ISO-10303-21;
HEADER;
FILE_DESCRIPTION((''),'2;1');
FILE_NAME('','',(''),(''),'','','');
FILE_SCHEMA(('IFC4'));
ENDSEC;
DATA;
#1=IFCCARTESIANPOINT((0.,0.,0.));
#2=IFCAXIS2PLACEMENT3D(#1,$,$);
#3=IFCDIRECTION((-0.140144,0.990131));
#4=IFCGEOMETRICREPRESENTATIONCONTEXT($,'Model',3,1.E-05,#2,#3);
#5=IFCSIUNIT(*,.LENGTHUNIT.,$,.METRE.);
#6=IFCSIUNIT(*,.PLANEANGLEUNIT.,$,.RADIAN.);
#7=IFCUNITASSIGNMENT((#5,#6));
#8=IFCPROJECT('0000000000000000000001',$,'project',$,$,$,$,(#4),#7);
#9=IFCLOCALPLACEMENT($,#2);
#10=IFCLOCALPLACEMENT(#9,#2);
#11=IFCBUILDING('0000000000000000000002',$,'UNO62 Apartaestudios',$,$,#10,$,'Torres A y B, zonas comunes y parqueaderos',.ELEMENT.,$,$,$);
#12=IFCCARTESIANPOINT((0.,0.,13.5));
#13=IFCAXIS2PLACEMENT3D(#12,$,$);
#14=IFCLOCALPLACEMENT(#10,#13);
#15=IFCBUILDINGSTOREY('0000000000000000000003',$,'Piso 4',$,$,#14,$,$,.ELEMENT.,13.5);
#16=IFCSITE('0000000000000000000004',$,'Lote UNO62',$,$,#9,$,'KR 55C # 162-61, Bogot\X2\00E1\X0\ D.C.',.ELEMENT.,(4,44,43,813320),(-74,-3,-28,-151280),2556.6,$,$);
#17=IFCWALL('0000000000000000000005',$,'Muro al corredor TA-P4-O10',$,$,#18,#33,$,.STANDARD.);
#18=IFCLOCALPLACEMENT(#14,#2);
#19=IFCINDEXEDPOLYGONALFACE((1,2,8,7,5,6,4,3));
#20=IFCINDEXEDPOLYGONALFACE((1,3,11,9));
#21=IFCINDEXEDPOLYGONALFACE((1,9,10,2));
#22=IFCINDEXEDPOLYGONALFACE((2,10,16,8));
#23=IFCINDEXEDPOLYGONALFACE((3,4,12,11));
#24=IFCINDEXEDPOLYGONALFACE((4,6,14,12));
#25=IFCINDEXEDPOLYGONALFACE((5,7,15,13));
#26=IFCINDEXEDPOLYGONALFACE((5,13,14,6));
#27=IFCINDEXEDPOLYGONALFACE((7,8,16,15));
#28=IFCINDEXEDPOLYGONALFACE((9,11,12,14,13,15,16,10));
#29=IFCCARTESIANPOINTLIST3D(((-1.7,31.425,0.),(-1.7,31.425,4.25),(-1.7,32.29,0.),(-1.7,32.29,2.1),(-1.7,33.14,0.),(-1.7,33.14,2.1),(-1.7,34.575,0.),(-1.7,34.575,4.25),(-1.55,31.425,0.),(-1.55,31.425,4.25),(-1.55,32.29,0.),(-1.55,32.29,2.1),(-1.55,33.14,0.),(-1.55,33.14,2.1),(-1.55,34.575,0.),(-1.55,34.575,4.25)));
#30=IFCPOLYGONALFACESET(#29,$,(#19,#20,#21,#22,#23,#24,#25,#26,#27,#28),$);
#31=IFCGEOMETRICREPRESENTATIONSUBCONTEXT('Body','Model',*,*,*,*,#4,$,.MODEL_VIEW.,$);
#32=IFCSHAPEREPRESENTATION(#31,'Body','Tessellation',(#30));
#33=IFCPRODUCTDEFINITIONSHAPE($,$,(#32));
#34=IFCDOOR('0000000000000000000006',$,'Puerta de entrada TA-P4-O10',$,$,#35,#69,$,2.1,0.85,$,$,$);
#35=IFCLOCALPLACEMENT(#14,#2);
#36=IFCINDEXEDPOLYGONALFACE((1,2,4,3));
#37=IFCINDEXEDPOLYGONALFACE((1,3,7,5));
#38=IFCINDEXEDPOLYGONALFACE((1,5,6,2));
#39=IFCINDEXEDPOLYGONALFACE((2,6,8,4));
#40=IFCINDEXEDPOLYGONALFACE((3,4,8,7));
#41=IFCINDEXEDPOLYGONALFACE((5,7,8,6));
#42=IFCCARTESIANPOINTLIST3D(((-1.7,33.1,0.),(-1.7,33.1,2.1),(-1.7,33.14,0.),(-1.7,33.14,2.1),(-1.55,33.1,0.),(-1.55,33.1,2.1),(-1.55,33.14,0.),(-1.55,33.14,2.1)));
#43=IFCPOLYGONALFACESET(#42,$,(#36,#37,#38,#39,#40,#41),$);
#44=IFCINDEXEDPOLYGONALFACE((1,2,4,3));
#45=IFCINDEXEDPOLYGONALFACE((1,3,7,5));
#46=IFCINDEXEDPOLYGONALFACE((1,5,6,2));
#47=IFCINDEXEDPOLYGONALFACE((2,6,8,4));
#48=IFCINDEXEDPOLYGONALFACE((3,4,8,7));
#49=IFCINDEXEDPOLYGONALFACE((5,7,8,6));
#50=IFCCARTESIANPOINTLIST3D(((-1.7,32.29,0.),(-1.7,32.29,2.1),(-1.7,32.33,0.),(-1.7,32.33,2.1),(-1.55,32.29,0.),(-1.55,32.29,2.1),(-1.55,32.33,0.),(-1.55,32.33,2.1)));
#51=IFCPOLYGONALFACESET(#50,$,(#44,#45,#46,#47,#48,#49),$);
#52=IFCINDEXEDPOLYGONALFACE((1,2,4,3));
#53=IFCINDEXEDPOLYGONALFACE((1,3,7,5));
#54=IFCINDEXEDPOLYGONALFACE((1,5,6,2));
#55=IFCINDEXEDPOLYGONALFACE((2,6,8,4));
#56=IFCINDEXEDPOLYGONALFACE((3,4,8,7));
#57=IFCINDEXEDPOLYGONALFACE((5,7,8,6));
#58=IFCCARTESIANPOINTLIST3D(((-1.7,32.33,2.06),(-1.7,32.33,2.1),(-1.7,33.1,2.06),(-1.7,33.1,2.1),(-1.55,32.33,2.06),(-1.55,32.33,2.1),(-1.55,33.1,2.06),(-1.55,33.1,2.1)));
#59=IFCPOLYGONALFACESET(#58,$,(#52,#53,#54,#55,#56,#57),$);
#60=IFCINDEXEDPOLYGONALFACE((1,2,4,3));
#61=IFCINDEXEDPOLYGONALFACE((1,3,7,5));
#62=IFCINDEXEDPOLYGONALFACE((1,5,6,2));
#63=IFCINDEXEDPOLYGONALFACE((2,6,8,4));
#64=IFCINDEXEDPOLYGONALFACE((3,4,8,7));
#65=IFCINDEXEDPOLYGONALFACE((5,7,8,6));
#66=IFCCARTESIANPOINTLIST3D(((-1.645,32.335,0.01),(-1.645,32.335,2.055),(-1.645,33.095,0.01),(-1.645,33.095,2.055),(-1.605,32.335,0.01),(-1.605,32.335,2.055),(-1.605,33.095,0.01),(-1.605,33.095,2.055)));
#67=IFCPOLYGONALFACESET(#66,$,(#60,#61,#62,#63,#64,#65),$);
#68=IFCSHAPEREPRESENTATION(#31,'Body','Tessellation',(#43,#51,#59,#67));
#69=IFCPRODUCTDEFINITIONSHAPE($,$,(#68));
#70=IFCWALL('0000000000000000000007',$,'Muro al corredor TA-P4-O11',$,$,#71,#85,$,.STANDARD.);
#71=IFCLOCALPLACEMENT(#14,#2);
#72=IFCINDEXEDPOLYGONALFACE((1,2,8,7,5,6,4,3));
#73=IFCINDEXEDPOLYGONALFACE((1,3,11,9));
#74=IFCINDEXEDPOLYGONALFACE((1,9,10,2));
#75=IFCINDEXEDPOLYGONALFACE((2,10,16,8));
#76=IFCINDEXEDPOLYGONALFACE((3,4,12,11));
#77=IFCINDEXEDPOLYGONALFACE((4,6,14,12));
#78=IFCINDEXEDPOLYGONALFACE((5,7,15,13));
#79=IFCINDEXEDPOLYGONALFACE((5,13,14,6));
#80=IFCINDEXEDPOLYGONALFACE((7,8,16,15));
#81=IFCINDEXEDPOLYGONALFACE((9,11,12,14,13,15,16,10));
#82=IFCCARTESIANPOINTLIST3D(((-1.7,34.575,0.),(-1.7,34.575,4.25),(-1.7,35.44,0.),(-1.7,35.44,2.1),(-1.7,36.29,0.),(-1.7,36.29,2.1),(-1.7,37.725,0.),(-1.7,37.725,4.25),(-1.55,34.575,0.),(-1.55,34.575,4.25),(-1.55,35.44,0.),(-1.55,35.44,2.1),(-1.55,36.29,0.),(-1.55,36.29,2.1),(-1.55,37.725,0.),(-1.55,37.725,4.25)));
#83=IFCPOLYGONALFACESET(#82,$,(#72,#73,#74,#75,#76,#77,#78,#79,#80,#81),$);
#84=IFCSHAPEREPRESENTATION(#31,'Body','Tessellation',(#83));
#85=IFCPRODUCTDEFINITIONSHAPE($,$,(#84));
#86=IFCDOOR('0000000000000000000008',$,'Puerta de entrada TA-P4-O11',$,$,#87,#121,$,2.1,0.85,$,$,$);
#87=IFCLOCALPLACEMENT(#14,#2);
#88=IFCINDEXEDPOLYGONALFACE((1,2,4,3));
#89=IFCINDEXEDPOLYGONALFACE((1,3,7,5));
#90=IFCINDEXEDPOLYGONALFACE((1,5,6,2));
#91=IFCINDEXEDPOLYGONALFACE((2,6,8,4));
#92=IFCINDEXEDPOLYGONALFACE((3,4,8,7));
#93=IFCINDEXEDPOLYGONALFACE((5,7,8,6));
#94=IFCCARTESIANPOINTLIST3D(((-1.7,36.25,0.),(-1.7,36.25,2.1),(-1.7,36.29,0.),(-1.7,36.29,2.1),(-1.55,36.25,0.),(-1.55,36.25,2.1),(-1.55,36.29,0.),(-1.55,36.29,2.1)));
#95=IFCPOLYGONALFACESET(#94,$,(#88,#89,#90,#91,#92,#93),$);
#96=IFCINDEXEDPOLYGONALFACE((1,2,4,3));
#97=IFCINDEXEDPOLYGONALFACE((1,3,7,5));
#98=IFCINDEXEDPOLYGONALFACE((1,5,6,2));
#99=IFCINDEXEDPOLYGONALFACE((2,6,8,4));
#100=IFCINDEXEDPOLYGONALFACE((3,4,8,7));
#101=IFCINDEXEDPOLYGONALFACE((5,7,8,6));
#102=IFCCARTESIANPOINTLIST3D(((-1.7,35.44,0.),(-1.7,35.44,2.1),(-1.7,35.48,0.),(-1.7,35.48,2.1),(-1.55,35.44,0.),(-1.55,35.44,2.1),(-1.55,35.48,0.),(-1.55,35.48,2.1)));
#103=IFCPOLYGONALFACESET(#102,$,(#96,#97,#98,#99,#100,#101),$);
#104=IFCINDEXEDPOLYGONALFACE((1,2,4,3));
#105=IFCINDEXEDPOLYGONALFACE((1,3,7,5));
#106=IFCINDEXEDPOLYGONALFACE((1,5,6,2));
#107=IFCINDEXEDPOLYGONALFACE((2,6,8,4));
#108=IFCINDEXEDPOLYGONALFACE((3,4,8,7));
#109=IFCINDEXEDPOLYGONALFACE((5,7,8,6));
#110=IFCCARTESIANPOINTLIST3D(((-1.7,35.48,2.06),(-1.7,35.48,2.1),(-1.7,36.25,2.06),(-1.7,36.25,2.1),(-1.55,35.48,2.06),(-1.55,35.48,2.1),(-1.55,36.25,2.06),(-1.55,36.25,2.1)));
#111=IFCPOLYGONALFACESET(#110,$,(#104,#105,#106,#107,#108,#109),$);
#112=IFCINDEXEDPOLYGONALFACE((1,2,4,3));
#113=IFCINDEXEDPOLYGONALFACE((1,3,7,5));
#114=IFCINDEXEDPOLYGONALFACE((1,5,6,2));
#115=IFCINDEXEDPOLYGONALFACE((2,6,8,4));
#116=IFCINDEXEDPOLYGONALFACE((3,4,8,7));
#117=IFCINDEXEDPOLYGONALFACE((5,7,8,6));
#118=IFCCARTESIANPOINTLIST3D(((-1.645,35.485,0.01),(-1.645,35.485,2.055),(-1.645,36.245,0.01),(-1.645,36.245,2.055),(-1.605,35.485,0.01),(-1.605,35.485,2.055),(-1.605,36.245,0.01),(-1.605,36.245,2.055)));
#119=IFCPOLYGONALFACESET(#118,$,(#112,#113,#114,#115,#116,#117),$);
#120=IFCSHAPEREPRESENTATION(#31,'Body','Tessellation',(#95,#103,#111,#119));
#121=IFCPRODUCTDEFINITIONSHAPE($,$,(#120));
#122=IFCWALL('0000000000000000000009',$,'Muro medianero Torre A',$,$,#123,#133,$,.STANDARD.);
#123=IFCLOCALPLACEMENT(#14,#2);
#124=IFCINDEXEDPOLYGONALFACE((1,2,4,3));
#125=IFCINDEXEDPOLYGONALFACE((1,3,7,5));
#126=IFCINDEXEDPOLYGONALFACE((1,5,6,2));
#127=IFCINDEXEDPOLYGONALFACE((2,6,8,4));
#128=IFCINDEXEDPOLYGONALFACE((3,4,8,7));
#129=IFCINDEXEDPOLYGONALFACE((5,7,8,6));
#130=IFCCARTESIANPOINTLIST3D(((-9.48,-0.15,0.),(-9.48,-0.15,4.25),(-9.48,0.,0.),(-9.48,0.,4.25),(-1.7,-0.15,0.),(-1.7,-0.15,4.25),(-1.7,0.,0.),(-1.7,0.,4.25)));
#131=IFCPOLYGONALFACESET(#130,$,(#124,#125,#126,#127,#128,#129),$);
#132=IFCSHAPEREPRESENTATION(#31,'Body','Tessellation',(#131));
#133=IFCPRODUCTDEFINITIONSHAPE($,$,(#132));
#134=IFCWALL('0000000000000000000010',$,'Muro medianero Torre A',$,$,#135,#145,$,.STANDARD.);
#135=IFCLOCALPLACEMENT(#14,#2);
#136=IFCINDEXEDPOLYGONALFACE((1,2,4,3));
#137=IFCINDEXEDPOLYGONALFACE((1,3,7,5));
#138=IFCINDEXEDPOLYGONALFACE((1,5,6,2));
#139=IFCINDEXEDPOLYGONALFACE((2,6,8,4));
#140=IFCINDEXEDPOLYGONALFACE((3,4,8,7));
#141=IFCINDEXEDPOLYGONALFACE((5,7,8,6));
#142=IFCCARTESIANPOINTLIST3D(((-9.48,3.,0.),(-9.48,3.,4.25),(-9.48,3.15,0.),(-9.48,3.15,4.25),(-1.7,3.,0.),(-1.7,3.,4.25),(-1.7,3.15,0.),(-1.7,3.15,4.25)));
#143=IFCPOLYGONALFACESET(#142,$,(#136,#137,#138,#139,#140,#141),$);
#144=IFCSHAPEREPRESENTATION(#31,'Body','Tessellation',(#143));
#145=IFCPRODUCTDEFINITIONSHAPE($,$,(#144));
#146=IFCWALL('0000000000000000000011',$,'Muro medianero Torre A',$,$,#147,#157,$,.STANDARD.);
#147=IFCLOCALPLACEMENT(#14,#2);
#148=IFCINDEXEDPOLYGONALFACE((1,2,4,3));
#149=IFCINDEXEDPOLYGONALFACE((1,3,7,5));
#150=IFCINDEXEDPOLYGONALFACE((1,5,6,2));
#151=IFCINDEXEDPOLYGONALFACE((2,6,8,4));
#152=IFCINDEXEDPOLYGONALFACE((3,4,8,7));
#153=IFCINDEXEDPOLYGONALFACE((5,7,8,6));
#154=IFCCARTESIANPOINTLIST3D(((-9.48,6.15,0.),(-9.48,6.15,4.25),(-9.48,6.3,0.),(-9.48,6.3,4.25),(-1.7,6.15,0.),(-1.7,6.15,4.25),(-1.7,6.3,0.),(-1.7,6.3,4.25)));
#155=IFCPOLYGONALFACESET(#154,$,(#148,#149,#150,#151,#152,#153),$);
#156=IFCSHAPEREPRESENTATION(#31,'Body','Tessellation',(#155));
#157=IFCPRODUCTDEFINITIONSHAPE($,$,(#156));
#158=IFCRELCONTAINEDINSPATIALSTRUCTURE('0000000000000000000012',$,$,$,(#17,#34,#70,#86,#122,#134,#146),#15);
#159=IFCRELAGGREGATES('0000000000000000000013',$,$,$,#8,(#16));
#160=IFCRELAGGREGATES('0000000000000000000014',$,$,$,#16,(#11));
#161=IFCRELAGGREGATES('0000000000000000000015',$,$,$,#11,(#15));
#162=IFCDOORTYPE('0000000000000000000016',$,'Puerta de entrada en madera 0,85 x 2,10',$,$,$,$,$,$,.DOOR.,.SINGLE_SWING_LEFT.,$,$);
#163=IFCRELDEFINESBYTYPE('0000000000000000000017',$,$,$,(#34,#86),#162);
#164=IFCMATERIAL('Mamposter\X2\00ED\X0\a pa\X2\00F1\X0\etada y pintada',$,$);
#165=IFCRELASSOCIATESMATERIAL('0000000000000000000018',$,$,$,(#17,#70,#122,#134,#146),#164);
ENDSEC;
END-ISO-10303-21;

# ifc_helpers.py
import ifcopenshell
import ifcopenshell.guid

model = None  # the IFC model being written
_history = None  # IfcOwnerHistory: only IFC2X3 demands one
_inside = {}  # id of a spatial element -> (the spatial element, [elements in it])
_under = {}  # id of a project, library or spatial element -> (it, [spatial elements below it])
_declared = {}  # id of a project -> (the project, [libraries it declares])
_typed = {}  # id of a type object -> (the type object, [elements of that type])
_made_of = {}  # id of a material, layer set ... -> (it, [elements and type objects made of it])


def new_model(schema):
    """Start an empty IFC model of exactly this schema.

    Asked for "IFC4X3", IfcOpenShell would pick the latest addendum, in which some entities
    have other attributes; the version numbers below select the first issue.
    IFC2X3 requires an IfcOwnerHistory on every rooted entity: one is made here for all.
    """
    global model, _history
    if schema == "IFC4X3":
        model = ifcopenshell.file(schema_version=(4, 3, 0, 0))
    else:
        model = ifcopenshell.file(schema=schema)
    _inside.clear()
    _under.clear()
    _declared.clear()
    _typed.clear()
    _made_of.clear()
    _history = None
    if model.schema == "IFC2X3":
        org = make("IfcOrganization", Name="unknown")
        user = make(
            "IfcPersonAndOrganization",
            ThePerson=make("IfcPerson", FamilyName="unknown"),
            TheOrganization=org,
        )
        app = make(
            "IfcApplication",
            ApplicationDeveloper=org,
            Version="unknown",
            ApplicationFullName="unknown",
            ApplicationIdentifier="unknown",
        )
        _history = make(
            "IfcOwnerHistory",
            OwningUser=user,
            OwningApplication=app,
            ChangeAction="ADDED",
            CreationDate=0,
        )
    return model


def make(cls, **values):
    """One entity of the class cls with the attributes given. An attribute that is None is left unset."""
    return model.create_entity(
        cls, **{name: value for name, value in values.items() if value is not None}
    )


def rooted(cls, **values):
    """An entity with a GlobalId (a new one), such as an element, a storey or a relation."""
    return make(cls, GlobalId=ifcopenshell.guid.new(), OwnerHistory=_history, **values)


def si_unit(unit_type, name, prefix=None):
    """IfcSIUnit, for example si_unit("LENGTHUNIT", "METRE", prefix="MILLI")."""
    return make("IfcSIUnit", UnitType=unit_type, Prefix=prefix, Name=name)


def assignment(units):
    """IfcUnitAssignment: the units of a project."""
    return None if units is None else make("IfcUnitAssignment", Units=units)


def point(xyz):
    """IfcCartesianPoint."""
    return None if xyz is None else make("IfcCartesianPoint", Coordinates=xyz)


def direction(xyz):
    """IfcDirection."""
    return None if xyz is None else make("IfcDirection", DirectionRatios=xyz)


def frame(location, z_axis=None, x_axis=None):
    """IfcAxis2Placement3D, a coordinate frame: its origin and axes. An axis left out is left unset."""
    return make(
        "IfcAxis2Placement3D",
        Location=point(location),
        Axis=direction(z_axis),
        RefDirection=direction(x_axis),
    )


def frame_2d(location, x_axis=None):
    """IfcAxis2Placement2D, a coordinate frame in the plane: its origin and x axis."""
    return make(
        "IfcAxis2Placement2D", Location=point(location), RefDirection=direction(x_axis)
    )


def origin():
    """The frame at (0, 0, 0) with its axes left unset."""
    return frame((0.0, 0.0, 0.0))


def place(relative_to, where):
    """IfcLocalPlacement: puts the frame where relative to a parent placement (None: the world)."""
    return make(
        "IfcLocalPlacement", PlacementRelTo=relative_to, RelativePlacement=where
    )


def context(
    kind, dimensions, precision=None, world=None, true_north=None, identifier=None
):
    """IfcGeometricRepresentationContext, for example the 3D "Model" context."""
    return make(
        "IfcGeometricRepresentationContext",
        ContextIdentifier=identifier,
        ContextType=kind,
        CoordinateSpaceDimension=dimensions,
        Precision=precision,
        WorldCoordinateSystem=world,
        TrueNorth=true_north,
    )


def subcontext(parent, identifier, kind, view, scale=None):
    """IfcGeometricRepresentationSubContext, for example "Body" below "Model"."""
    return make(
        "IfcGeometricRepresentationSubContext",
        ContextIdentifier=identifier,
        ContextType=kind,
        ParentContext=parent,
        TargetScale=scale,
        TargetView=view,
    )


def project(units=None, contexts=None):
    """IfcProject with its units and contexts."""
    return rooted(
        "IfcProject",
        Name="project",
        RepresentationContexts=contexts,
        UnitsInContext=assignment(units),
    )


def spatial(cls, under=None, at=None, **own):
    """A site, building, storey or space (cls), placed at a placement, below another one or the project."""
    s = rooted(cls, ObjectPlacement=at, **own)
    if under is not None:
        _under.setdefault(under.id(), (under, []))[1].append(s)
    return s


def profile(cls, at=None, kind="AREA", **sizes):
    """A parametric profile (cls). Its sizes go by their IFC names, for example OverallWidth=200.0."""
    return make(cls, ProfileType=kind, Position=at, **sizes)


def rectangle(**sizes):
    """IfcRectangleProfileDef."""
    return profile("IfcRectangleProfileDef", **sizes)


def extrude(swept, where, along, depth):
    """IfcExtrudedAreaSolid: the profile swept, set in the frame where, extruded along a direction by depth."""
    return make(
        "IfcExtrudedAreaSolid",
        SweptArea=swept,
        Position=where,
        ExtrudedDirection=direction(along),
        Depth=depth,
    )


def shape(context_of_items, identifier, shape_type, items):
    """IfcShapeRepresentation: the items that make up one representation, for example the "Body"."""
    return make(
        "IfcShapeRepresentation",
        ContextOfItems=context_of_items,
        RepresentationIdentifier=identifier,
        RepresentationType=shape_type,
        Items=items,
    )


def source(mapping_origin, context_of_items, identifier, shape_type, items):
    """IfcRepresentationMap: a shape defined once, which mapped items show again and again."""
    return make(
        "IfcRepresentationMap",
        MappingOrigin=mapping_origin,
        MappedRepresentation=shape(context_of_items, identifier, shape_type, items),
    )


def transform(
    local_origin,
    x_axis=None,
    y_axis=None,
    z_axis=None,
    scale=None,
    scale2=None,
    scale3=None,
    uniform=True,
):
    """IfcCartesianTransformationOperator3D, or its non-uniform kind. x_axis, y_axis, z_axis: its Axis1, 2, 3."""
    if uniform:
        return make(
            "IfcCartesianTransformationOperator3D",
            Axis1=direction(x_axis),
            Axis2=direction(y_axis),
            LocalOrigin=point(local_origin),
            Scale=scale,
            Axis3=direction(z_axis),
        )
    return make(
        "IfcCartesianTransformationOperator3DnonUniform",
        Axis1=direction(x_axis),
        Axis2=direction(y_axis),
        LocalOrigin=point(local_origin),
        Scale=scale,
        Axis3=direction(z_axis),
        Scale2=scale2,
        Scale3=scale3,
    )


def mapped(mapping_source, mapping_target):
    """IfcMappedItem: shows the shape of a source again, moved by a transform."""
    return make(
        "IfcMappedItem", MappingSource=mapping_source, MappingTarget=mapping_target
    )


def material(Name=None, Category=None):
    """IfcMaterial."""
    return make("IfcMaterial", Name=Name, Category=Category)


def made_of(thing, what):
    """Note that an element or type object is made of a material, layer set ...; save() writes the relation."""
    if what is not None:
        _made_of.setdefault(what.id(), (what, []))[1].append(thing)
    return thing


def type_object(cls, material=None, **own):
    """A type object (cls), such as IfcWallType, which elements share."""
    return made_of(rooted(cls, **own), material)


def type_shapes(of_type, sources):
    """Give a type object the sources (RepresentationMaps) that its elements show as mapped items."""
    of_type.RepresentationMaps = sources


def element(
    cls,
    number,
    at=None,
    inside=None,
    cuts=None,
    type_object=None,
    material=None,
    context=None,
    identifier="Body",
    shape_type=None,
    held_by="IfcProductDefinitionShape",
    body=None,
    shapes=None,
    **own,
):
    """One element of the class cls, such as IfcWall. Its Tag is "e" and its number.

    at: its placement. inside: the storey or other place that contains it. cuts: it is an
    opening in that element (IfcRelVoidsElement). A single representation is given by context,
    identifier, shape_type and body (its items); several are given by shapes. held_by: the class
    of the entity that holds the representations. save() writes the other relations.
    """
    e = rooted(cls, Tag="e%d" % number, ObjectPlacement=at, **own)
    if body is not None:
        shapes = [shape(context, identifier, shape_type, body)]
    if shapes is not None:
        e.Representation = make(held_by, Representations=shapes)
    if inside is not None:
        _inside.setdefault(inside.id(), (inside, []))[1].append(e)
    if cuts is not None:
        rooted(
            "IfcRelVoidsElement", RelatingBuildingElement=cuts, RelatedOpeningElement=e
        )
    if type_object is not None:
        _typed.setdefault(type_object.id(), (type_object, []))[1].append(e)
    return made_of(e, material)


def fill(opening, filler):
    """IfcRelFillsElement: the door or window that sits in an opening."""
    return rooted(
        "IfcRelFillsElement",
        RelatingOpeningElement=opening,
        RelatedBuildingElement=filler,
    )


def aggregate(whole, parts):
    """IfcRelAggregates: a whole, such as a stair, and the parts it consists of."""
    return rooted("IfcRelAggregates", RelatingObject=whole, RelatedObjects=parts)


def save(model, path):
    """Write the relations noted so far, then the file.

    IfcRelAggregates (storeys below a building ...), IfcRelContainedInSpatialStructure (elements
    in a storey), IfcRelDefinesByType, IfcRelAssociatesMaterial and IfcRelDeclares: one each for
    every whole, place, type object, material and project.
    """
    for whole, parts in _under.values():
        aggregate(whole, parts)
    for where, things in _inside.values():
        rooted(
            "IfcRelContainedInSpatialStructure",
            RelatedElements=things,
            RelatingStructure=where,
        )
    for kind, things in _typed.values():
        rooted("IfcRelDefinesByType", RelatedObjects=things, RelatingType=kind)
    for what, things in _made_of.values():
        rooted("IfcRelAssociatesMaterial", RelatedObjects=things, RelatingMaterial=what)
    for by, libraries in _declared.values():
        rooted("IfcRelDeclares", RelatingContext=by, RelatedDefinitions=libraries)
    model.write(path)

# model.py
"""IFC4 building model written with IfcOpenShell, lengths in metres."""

from ifc_helpers import new_model, si_unit, direction, frame, frame_2d, origin, place, context, subcontext, project, spatial, rectangle, extrude, source, transform, mapped, material, type_object, type_shapes, element, fill, save


model = new_model("IFC4")

# Units and contexts
model_context = context("Model", 3, precision=1e-05, world=origin(), true_north=direction((-0.140144, 0.990131)))
body_context = subcontext(model_context, "Body", "Model", "MODEL_VIEW")
ifc_project = project(units=[si_unit("LENGTHUNIT", "METRE"), si_unit("PLANEANGLEUNIT", "RADIAN")], contexts=[model_context])

# Site, building, storey
site_placement = place(None, origin())
site = spatial("IfcSite", under=ifc_project, at=site_placement, Name="Lote UNO62", LongName="KR 55C # 162-61, Bogotá D.C.", CompositionType="ELEMENT", RefLatitude=(4, 44, 43, 813320), RefLongitude=(-74, -3, -28, -151280), RefElevation=2556.6)
building_placement = place(site_placement, origin())
building = spatial("IfcBuilding", under=site, at=building_placement, Name="UNO62 Apartaestudios", LongName="Torres A y B, zonas comunes y parqueaderos", CompositionType="ELEMENT")
storey_placement = place(building_placement, frame((0.0, 0.0, 13.5)))
storey = spatial("IfcBuildingStorey", under=building, at=storey_placement, Name="Piso 4", CompositionType="ELEMENT", Elevation=13.5)

# Walls, openings, doors
ifc_material = material(Name="Mampostería pañetada y pintada")
door_type = type_object("IfcDoorType", Name="Puerta de entrada en madera 0,85 x 2,10", OperationType="SINGLE_SWING_LEFT", PredefinedType="DOOR")
shared_shape = source(origin(), body_context, "Body", "SweptSolid", [
    extrude(rectangle(XDim=0.15, YDim=0.04, at=frame_2d((-0.075, 1.38))), origin(), (0.0, 0.0, 1.0), 2.1),
    extrude(rectangle(XDim=0.15, YDim=0.04, at=frame_2d((-0.075, 2.19))), origin(), (0.0, 0.0, 1.0), 2.1),
    extrude(rectangle(XDim=0.15, YDim=0.77, at=frame_2d((-0.075, 1.785))), frame((0.0, 0.0, 2.06)), (0.0, 0.0, 1.0), 0.04),
    extrude(rectangle(XDim=0.04, YDim=0.76, at=frame_2d((-0.075, 1.785))), frame((0.0, 0.0, 0.01)), (0.0, 0.0, 1.0), 2.045),
])
type_shapes(door_type, [shared_shape])
wall_1_placement = place(storey_placement, origin())
wall_1 = element("IfcWall", 1, at=wall_1_placement, inside=storey, material=ifc_material, Name="Muro al corredor TA-P4-O10", PredefinedType="STANDARD", context=body_context, shape_type="SweptSolid", body=[
    extrude(rectangle(XDim=0.15, YDim=3.15, at=frame_2d((-1.625, 33.0))), origin(), (0.0, 0.0, 1.0), 4.25),
])
opening_1_placement = place(wall_1_placement, origin())
opening_1 = element("IfcOpeningElement", 2, at=opening_1_placement, cuts=wall_1, PredefinedType="OPENING", context=body_context, shape_type="SweptSolid", body=[
    extrude(rectangle(XDim=0.25, YDim=0.85, at=frame_2d((-1.625, 32.715))), origin(), (0.0, 0.0, 1.0), 2.1),
])
placement_1 = place(storey_placement, frame((-1.7, 34.5, 0.0), z_axis=(0.0, 0.0, 1.0), x_axis=(-1.0, 0.0, 0.0)))
door_1_placement = place(placement_1, origin())
door_1 = element("IfcDoor", 3, at=door_1_placement, inside=storey, type_object=door_type, Name="Puerta de entrada TA-P4-O10", OverallHeight=2.1, OverallWidth=0.85, context=body_context, shape_type="MappedRepresentation", body=[
    mapped(shared_shape, transform((0.0, 0.0, 0.0))),
])
fill(opening_1, door_1)
wall_2_placement = place(storey_placement, origin())
wall_2 = element("IfcWall", 4, at=wall_2_placement, inside=storey, material=ifc_material, Name="Muro al corredor TA-P4-O11", PredefinedType="STANDARD", context=body_context, shape_type="SweptSolid", body=[
    extrude(rectangle(XDim=0.15, YDim=3.15, at=frame_2d((-1.625, 36.15))), origin(), (0.0, 0.0, 1.0), 4.25),
])
opening_2_placement = place(wall_2_placement, origin())
opening_2 = element("IfcOpeningElement", 5, at=opening_2_placement, cuts=wall_2, PredefinedType="OPENING", context=body_context, shape_type="SweptSolid", body=[
    extrude(rectangle(XDim=0.25, YDim=0.85, at=frame_2d((-1.625, 35.865))), origin(), (0.0, 0.0, 1.0), 2.1),
])
placement_2 = place(storey_placement, frame((-1.7, 37.65, 0.0), z_axis=(0.0, 0.0, 1.0), x_axis=(-1.0, 0.0, 0.0)))
door_2_placement = place(placement_2, origin())
door_2 = element("IfcDoor", 6, at=door_2_placement, inside=storey, type_object=door_type, Name="Puerta de entrada TA-P4-O11", OverallHeight=2.1, OverallWidth=0.85, context=body_context, shape_type="MappedRepresentation", body=[
    mapped(shared_shape, transform((0.0, 0.0, 0.0))),
])
fill(opening_2, door_2)

# Walls
wall_3_placement = place(storey_placement, origin())
element("IfcWall", 7, at=wall_3_placement, inside=storey, material=ifc_material, Name="Muro medianero Torre A", PredefinedType="STANDARD", context=body_context, shape_type="SweptSolid", body=[
    extrude(rectangle(XDim=7.78, YDim=0.15, at=frame_2d((-5.59, -0.075))), origin(), (0.0, 0.0, 1.0), 4.25),
])
wall_4_placement = place(storey_placement, origin())
element("IfcWall", 8, at=wall_4_placement, inside=storey, material=ifc_material, Name="Muro medianero Torre A", PredefinedType="STANDARD", context=body_context, shape_type="SweptSolid", body=[
    extrude(rectangle(XDim=7.78, YDim=0.15, at=frame_2d((-5.59, 3.075))), origin(), (0.0, 0.0, 1.0), 4.25),
])
wall_5_placement = place(storey_placement, origin())
element("IfcWall", 9, at=wall_5_placement, inside=storey, material=ifc_material, Name="Muro medianero Torre A", PredefinedType="STANDARD", context=body_context, shape_type="SweptSolid", body=[
    extrude(rectangle(XDim=7.78, YDim=0.15, at=frame_2d((-5.59, 6.225))), origin(), (0.0, 0.0, 1.0), 4.25),
])

save(model, "model.ifc")
